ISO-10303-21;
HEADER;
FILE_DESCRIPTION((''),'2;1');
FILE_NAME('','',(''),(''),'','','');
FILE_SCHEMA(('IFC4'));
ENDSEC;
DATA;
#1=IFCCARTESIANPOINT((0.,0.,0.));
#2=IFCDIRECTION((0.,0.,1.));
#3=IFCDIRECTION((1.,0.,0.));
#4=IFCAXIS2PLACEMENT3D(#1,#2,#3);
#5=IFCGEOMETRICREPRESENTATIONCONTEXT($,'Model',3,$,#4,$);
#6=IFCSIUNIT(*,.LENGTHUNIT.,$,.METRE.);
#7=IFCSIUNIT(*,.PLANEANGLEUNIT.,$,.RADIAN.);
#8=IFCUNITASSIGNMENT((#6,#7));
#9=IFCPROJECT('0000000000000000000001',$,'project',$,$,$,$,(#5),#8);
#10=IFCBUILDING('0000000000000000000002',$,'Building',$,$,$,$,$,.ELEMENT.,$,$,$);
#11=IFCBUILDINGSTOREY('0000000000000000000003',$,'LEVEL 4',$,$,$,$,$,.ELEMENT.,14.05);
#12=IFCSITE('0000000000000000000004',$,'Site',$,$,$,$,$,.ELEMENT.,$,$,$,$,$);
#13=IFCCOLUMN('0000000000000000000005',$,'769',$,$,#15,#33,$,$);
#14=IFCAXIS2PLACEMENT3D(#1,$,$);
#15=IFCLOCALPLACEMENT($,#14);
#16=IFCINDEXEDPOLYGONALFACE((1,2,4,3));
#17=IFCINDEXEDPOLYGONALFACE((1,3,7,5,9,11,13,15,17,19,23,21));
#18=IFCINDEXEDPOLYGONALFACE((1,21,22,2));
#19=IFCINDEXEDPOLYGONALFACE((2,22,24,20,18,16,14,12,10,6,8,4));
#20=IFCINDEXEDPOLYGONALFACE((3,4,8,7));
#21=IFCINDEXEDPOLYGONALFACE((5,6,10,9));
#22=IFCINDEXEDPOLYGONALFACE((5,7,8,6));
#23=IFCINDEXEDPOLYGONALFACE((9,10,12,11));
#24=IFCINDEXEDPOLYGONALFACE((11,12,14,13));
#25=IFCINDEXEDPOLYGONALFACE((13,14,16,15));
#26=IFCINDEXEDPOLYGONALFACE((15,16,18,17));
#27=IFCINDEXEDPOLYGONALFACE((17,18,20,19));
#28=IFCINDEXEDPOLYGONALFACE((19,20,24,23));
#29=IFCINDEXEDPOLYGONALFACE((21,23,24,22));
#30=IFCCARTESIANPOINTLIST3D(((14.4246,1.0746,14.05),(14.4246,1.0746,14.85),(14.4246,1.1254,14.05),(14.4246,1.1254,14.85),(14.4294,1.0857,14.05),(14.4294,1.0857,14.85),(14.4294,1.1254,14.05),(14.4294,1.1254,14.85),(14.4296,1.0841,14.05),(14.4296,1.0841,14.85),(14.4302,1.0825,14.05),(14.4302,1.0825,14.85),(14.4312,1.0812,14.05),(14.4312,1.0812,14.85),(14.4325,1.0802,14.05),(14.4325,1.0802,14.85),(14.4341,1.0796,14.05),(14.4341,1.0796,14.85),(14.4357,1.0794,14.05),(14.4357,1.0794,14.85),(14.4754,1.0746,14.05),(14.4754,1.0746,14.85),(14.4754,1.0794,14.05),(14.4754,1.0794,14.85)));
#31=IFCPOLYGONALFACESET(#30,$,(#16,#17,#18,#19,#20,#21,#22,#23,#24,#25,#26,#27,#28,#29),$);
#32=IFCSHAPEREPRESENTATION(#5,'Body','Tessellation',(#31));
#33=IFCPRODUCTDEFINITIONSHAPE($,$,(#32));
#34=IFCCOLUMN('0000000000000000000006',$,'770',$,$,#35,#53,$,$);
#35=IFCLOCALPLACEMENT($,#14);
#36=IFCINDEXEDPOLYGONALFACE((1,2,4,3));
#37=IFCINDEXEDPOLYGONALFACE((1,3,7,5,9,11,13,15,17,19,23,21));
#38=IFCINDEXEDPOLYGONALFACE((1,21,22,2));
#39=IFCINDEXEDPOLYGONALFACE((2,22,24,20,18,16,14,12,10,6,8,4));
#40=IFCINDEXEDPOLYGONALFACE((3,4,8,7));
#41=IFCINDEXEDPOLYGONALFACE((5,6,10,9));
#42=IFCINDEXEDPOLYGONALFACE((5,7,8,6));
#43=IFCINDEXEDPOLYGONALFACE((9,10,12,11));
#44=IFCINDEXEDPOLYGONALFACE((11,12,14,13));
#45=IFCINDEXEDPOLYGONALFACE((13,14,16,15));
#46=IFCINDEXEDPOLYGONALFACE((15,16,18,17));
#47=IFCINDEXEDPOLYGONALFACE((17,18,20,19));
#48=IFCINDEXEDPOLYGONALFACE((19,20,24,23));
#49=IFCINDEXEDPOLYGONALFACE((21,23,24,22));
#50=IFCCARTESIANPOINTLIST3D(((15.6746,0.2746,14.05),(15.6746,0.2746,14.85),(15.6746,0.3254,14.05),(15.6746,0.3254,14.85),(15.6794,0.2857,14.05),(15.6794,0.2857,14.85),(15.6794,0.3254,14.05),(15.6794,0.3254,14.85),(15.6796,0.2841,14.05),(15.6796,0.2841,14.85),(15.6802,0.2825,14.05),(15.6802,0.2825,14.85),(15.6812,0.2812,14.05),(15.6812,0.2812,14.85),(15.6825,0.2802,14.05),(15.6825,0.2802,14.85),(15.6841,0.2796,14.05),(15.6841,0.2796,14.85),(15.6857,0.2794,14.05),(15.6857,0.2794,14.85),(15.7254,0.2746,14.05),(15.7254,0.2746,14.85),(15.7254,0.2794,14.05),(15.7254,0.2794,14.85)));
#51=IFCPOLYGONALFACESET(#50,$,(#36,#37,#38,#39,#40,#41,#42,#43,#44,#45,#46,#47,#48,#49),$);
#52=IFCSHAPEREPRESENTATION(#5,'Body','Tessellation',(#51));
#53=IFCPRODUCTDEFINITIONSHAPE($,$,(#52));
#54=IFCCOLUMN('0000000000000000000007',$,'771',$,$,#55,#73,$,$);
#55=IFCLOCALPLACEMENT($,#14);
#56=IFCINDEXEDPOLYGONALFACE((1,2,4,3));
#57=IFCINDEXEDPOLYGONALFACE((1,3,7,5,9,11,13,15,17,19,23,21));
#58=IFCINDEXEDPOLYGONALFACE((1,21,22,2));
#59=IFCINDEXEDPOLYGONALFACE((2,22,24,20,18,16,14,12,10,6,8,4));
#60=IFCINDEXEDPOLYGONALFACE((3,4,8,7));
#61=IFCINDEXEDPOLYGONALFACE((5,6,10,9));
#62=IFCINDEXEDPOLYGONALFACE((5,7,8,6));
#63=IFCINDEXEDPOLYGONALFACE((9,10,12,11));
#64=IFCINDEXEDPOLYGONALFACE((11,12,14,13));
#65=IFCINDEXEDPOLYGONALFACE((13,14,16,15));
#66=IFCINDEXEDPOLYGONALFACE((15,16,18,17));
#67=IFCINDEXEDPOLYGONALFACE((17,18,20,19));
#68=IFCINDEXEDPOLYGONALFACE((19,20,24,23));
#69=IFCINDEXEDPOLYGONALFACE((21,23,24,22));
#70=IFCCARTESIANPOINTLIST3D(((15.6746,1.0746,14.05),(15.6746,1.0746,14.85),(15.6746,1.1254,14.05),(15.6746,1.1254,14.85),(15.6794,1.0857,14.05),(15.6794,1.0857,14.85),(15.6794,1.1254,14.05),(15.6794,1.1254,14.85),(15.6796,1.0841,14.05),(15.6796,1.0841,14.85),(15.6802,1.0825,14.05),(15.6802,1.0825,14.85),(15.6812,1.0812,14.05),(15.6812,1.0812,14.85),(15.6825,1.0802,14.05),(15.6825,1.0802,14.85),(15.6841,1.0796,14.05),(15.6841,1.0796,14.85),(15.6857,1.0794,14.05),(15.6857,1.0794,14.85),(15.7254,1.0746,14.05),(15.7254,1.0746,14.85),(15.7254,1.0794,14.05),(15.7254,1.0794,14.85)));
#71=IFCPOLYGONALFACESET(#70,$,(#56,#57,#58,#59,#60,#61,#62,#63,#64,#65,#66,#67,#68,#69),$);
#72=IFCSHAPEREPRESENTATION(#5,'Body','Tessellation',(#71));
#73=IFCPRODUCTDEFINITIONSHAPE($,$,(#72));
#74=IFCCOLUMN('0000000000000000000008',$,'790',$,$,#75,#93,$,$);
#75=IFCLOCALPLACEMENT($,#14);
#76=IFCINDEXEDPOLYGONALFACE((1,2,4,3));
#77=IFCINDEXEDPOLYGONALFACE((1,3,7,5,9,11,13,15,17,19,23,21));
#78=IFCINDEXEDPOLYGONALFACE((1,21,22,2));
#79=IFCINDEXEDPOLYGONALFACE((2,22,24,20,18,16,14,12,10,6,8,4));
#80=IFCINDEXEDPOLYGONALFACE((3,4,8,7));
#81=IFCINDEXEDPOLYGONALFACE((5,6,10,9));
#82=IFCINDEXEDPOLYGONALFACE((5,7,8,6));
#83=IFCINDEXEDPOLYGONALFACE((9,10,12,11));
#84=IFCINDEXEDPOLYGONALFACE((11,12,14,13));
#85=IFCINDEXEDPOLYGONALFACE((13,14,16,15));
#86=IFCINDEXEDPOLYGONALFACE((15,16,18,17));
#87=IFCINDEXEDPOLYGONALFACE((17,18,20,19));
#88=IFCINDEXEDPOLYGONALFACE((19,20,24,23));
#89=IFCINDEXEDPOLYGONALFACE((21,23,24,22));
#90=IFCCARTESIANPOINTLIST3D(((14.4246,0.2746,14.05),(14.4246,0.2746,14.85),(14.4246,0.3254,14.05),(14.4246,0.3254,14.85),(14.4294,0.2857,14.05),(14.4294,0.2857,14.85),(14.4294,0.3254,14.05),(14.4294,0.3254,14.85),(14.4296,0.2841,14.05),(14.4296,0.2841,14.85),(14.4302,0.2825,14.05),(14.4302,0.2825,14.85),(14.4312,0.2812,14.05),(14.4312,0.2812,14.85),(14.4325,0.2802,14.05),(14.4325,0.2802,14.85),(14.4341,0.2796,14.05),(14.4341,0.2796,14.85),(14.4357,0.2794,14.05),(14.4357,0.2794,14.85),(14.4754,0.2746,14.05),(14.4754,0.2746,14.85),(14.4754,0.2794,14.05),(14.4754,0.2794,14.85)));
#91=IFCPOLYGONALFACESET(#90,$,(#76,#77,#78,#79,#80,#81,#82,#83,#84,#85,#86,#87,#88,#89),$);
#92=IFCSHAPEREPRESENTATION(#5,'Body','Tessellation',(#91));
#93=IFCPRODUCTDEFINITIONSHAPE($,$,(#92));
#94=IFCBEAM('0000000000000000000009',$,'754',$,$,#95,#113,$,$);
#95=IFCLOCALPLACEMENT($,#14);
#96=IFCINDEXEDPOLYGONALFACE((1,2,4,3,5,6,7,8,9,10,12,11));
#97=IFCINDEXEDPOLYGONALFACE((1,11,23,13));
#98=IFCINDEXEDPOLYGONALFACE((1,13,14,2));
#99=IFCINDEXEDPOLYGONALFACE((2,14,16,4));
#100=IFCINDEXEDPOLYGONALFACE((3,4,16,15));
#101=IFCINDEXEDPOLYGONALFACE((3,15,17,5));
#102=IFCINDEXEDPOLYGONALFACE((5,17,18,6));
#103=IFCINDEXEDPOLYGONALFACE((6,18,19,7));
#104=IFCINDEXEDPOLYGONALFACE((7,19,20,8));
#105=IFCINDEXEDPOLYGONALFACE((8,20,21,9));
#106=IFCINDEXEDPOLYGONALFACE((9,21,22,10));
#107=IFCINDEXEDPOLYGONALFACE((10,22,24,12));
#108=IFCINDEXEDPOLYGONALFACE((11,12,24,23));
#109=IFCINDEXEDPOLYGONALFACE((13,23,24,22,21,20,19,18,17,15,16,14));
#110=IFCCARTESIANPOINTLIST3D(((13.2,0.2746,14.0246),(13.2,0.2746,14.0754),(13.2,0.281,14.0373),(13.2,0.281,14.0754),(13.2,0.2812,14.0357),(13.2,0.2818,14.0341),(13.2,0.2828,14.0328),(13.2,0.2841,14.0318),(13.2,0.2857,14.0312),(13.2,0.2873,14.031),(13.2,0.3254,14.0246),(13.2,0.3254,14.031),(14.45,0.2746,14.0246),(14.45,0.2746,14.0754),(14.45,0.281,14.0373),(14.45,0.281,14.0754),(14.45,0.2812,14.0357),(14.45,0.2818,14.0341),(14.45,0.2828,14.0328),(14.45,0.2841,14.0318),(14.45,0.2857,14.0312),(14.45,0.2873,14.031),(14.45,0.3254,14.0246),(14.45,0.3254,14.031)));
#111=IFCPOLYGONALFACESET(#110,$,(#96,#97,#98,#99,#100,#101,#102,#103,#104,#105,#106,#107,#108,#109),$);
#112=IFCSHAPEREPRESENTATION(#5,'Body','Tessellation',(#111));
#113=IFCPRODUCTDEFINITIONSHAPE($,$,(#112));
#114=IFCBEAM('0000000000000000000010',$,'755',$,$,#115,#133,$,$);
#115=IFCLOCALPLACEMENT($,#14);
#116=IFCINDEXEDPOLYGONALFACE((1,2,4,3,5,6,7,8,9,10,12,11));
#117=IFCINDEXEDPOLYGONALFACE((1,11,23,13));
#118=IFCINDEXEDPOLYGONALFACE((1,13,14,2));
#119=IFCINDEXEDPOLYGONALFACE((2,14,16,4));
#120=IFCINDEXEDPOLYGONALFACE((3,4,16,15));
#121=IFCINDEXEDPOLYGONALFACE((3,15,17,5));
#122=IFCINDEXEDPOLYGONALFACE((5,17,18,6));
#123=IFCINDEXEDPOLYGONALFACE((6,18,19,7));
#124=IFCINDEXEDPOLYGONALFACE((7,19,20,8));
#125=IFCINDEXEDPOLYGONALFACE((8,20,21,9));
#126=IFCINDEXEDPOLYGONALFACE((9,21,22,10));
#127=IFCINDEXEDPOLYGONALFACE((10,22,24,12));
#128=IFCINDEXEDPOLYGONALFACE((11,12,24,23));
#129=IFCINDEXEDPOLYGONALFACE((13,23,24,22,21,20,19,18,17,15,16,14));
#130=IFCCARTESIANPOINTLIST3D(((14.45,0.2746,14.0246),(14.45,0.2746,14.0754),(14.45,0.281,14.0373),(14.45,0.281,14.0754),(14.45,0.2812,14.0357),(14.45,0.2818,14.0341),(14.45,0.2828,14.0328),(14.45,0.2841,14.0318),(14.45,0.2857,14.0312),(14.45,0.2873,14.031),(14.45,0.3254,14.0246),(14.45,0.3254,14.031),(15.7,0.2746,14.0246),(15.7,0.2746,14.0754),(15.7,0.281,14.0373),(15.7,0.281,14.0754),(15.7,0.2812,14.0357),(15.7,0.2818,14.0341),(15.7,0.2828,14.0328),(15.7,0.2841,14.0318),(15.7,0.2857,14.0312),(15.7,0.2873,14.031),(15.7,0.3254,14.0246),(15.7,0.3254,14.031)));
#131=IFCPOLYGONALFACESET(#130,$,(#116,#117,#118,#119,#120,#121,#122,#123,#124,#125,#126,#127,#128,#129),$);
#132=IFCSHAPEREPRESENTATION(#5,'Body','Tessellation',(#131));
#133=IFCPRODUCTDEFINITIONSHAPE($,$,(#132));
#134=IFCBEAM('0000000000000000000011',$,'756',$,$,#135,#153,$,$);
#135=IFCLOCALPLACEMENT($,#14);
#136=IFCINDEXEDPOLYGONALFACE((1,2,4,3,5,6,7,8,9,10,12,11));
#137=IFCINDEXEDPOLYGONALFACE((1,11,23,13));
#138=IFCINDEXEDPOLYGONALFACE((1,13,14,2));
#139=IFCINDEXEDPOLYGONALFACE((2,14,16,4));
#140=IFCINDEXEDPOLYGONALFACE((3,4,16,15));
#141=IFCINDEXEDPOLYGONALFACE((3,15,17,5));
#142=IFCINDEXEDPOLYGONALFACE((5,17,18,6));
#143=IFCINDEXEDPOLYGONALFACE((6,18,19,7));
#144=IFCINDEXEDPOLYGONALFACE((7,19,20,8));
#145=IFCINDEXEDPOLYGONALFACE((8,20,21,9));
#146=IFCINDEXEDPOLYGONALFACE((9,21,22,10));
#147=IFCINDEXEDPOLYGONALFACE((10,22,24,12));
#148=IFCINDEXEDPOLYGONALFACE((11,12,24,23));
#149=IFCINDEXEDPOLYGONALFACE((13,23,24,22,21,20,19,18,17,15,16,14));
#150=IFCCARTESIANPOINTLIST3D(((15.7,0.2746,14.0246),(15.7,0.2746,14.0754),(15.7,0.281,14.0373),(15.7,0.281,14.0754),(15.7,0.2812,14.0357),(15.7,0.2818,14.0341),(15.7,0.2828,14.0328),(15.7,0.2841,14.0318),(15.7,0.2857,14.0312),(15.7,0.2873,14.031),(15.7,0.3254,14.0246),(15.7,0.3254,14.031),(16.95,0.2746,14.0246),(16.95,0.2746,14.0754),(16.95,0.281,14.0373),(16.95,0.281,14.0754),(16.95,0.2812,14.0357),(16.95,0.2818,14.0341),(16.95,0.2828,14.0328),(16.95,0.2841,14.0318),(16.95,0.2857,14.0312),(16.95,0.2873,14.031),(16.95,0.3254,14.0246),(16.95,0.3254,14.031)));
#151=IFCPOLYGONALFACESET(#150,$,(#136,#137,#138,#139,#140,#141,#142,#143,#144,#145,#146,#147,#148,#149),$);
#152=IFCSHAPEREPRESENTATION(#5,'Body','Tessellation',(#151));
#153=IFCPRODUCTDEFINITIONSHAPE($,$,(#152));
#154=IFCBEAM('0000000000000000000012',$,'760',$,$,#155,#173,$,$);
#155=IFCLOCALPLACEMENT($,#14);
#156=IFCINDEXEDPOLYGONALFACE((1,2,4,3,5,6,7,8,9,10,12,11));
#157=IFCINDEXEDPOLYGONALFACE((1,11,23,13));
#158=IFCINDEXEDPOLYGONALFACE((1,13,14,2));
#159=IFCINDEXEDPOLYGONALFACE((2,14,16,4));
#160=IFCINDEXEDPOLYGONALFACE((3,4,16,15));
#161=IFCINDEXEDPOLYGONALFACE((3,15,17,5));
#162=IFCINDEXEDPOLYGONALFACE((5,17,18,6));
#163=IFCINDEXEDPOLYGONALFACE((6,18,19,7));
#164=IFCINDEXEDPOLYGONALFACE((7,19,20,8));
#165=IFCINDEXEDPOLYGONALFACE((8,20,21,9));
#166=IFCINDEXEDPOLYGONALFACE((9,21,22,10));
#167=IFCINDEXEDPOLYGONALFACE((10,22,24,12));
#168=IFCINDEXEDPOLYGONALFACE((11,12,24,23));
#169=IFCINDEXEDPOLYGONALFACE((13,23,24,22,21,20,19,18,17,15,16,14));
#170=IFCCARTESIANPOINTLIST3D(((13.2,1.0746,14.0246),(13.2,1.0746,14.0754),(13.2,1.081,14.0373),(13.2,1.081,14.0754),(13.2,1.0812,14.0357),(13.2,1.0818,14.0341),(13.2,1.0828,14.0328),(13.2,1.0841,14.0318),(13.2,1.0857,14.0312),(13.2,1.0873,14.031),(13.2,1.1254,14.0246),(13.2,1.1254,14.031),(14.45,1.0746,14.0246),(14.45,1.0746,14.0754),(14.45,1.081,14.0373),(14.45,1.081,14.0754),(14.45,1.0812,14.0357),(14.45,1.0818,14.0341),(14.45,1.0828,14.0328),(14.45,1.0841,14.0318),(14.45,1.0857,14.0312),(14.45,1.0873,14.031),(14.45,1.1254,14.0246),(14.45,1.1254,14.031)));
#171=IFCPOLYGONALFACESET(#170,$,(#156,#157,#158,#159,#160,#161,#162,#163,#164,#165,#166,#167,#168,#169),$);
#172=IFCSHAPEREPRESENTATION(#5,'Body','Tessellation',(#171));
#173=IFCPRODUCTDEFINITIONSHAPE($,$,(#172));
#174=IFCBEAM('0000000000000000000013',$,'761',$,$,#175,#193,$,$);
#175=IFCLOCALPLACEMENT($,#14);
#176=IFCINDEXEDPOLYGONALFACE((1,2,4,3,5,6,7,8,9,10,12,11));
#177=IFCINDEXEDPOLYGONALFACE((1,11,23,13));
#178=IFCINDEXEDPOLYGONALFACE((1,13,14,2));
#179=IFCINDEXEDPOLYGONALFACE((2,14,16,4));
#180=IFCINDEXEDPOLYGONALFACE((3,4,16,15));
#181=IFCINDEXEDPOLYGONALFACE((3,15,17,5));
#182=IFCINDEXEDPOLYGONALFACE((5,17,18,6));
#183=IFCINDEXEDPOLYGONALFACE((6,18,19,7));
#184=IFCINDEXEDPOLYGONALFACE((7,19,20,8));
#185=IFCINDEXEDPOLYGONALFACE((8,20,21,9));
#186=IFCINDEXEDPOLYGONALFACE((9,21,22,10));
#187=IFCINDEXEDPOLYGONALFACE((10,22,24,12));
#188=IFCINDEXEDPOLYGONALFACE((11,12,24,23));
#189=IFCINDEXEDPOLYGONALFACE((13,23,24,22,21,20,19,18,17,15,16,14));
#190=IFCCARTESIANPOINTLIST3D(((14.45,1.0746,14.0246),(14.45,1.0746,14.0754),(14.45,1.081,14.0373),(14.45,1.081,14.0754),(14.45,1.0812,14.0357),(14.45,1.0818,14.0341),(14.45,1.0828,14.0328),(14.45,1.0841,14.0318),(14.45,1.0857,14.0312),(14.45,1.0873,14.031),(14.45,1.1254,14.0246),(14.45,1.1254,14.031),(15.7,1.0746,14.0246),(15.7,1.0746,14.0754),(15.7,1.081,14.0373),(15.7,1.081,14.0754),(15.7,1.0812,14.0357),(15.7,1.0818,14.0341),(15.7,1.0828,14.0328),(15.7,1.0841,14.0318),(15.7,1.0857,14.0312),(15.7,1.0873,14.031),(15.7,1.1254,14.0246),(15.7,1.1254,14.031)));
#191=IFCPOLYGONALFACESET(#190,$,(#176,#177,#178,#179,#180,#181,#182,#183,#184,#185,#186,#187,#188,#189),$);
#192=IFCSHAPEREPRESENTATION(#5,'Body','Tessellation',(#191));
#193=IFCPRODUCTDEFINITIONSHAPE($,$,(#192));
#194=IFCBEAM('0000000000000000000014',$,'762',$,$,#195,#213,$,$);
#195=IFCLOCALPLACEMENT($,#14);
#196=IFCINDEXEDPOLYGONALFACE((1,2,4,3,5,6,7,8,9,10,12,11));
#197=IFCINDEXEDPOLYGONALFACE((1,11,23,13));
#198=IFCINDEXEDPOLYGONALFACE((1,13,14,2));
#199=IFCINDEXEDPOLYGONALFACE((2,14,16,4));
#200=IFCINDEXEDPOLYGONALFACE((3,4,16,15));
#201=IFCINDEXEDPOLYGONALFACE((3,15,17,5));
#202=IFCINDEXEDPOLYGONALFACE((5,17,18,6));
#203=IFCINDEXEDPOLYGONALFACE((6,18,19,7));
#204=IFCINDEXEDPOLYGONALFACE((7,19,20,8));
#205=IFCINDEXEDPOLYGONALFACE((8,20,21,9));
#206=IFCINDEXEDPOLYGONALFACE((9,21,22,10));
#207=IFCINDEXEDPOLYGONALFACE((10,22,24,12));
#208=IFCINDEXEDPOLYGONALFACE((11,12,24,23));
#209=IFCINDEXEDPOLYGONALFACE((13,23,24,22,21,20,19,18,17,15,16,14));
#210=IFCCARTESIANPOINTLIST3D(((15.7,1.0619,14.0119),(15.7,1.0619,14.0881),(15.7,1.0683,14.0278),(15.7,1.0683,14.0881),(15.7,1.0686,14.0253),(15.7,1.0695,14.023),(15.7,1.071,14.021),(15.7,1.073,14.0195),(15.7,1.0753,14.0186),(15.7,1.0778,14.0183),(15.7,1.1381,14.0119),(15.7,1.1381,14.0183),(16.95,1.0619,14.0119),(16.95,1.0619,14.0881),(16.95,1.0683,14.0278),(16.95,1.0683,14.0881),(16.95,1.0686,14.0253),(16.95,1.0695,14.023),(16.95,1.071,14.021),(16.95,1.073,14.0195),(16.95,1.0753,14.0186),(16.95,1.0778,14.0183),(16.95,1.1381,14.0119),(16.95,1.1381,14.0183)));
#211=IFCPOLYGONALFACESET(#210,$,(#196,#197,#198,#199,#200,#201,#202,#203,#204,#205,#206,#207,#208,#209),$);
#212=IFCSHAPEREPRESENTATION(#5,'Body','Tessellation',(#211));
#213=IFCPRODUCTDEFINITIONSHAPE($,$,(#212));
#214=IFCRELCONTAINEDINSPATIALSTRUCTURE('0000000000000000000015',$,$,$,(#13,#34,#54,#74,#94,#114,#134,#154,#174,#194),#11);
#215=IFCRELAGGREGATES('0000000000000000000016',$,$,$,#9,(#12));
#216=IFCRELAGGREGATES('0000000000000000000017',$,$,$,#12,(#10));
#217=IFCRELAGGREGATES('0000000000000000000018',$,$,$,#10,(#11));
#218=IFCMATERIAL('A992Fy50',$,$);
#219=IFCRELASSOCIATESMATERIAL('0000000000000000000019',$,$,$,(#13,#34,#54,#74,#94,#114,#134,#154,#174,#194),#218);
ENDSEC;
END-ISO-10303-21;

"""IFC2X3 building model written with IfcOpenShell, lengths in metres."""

from ifc_helpers import new_model, si_unit, frame, origin_with_axes, origin_2d_with_axis, place, context, project, spatial, l_section, extrude, material, element, save


model = new_model("IFC2X3")

# Units and contexts
model_context = context("Model", 3, world=origin_with_axes())
ifc_project = project(units=[si_unit("LENGTHUNIT", "METRE"), si_unit("PLANEANGLEUNIT", "RADIAN")], contexts=[model_context])

# Site, building, storey
site = spatial("IfcSite", under=ifc_project, Name="Site", CompositionType="ELEMENT")
building = spatial("IfcBuilding", under=site, Name="Building", CompositionType="ELEMENT")
storey = spatial("IfcBuildingStorey", under=building, Name="LEVEL 4", CompositionType="ELEMENT", Elevation=14.05)

# Columns
ifc_material = material(Name="A992Fy50")
for number, where, z_axis, x_axis, name in (
    (1, (14.45, 1.1, 14.85), (0.0, 0.0, -1.0), (0.0, 1.0, 0.0), "769"),
    (2, (15.7, 0.3, 14.85), (0.0, 0.0, -1.0), (0.0, 1.0, 0.0), "770"),
    (3, (15.7, 1.1, 14.85), (0.0, 0.0, -1.0), (0.0, 1.0, 0.0), "771"),
    (4, (14.45, 0.3, 14.85), (0.0, 0.0, -1.0), (0.0, 1.0, 0.0), "790"),
):
    element("IfcColumn", number, at=place(None, frame(where, z_axis=z_axis, x_axis=x_axis)), inside=storey, material=ifc_material, Name=name, context=model_context, shape_type="SweptSolid", body=[
        extrude(l_section(Depth=0.0508, Width=0.0508, Thickness=0.0048, FilletRadius=0.0063, at=origin_2d_with_axis()), origin_with_axes(), (0.0, 0.0, 1.0), 0.8),
    ])

# Beams
for number, where, z_axis, x_axis, name in (
    (5, (13.2, 0.3, 14.05), (1.0, 0.0, 0.0), (0.0, 1.0, 0.0), "754"),
    (6, (14.45, 0.3, 14.05), (1.0, 0.0, 0.0), (0.0, 1.0, 0.0), "755"),
    (7, (15.7, 0.3, 14.05), (1.0, 0.0, 0.0), (0.0, 1.0, 0.0), "756"),
    (8, (13.2, 1.1, 14.05), (1.0, 0.0, 0.0), (0.0, 1.0, 0.0), "760"),
    (9, (14.45, 1.1, 14.05), (1.0, 0.0, 0.0), (0.0, 1.0, 0.0), "761"),
):
    element("IfcBeam", number, at=place(None, frame(where, z_axis=z_axis, x_axis=x_axis)), inside=storey, material=ifc_material, Name=name, context=model_context, shape_type="SweptSolid", body=[
        extrude(l_section(Depth=0.0508, Width=0.0508, Thickness=0.0063, FilletRadius=0.0063, at=origin_2d_with_axis()), origin_with_axes(), (0.0, 0.0, 1.0), 1.25),
    ])
beam_placement = place(None, frame((15.7, 1.1, 14.05), z_axis=(1.0, 0.0, 0.0), x_axis=(0.0, 1.0, 0.0)))
element("IfcBeam", 10, at=beam_placement, inside=storey, material=ifc_material, Name="762", context=model_context, shape_type="SweptSolid", body=[
    extrude(l_section(Depth=0.0762, Width=0.0762, Thickness=0.0063, FilletRadius=0.0095, at=origin_2d_with_axis()), origin_with_axes(), (0.0, 0.0, 1.0), 1.25),
])

save(model, "model.ifc")
